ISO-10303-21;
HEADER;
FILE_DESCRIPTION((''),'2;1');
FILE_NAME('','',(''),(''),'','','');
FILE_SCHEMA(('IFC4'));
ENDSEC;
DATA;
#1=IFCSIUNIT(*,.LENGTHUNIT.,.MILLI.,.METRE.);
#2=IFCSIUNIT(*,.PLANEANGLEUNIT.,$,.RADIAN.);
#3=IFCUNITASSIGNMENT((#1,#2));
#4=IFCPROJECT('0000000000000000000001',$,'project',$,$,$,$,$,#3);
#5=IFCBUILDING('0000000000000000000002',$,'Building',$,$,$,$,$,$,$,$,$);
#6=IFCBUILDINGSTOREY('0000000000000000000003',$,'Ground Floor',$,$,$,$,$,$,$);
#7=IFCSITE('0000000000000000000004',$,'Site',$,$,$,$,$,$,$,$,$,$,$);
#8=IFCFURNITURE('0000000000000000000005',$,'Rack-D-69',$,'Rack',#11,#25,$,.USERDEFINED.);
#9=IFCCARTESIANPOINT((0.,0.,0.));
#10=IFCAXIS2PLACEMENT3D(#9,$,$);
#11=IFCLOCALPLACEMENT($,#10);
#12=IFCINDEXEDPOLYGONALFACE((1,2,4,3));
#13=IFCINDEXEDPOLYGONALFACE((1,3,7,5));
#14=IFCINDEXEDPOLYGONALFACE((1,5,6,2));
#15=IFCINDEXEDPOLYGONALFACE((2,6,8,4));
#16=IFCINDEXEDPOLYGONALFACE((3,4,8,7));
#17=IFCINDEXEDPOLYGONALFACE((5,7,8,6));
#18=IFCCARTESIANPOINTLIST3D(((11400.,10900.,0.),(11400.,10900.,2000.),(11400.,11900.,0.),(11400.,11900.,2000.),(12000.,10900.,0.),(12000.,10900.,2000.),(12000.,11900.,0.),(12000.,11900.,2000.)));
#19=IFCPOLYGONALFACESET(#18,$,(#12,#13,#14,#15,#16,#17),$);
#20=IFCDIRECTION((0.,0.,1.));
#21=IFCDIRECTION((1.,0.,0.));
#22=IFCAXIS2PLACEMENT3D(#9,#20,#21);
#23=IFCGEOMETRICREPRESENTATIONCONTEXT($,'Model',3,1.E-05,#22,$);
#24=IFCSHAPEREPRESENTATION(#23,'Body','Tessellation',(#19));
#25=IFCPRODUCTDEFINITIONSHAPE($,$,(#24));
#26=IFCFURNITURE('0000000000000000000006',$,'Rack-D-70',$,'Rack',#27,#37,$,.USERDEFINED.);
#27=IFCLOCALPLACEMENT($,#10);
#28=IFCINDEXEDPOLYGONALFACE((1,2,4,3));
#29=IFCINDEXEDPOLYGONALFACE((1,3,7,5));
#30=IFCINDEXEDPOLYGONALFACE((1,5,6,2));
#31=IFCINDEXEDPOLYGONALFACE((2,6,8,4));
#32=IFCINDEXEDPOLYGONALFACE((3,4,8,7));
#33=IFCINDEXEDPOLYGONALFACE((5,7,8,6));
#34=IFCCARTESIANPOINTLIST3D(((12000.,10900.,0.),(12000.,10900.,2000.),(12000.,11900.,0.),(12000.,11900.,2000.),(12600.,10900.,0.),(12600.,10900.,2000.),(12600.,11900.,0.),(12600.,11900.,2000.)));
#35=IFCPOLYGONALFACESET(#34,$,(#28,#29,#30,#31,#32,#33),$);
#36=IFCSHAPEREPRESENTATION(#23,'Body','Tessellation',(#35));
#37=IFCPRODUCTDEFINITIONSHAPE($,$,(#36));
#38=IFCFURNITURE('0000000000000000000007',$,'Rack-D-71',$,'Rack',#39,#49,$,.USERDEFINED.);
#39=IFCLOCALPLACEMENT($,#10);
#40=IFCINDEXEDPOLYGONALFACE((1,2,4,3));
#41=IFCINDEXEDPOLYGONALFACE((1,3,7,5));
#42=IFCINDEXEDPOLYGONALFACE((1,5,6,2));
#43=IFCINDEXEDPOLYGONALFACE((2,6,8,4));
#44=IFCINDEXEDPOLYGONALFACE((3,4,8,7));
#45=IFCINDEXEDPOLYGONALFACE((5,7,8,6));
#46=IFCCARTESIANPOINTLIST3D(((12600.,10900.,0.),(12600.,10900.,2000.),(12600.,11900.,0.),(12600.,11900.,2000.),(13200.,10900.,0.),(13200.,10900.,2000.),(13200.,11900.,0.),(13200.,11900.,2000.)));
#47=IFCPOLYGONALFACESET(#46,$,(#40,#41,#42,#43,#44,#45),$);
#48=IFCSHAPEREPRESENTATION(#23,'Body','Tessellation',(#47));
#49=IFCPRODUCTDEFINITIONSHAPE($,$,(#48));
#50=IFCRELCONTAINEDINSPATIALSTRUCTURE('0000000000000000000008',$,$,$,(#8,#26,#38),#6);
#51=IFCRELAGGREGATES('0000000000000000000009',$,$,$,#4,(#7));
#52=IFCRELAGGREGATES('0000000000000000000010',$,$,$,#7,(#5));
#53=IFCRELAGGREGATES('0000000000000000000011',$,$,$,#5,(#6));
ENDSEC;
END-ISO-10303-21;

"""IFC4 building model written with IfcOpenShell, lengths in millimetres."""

from ifc_helpers import new_model, si_unit, frame, origin_with_axes, place, context, project, spatial, rectangle, extrude, element, save


model = new_model("IFC4")

# Units and contexts
model_context = context("Model", 3, precision=1e-05, world=origin_with_axes())
ifc_project = project(units=[si_unit("LENGTHUNIT", "METRE", prefix="MILLI"), si_unit("PLANEANGLEUNIT", "RADIAN")])

# Site, building, storey
site = spatial("IfcSite", under=ifc_project, Name="Site")
building = spatial("IfcBuilding", under=site, Name="Building")
storey = spatial("IfcBuildingStorey", under=building, Name="Ground Floor")

# Furniture
furniture_1_placement = place(None, origin_with_axes())
element("IfcFurniture", 1, at=furniture_1_placement, inside=storey, Name="Rack-D-69", ObjectType="Rack", PredefinedType="USERDEFINED", context=model_context, shape_type="SweptSolid", body=[
    extrude(rectangle(XDim=600.0, YDim=1000.0), frame((11700.0, 11400.0, 0.0), z_axis=(0.0, 0.0, 1.0), x_axis=(1.0, 0.0, 0.0)), (0.0, 0.0, 1.0), 2000.0),
])
furniture_2_placement = place(None, origin_with_axes())
element("IfcFurniture", 2, at=furniture_2_placement, inside=storey, Name="Rack-D-70", ObjectType="Rack", PredefinedType="USERDEFINED", context=model_context, shape_type="SweptSolid", body=[
    extrude(rectangle(XDim=600.0, YDim=1000.0), frame((12300.0, 11400.0, 0.0), z_axis=(0.0, 0.0, 1.0), x_axis=(1.0, 0.0, 0.0)), (0.0, 0.0, 1.0), 2000.0),
])
furniture_3_placement = place(None, origin_with_axes())
element("IfcFurniture", 3, at=furniture_3_placement, inside=storey, Name="Rack-D-71", ObjectType="Rack", PredefinedType="USERDEFINED", context=model_context, shape_type="SweptSolid", body=[
    extrude(rectangle(XDim=600.0, YDim=1000.0), frame((12900.0, 11400.0, 0.0), z_axis=(0.0, 0.0, 1.0), x_axis=(1.0, 0.0, 0.0)), (0.0, 0.0, 1.0), 2000.0),
])

save(model, "model.ifc")
